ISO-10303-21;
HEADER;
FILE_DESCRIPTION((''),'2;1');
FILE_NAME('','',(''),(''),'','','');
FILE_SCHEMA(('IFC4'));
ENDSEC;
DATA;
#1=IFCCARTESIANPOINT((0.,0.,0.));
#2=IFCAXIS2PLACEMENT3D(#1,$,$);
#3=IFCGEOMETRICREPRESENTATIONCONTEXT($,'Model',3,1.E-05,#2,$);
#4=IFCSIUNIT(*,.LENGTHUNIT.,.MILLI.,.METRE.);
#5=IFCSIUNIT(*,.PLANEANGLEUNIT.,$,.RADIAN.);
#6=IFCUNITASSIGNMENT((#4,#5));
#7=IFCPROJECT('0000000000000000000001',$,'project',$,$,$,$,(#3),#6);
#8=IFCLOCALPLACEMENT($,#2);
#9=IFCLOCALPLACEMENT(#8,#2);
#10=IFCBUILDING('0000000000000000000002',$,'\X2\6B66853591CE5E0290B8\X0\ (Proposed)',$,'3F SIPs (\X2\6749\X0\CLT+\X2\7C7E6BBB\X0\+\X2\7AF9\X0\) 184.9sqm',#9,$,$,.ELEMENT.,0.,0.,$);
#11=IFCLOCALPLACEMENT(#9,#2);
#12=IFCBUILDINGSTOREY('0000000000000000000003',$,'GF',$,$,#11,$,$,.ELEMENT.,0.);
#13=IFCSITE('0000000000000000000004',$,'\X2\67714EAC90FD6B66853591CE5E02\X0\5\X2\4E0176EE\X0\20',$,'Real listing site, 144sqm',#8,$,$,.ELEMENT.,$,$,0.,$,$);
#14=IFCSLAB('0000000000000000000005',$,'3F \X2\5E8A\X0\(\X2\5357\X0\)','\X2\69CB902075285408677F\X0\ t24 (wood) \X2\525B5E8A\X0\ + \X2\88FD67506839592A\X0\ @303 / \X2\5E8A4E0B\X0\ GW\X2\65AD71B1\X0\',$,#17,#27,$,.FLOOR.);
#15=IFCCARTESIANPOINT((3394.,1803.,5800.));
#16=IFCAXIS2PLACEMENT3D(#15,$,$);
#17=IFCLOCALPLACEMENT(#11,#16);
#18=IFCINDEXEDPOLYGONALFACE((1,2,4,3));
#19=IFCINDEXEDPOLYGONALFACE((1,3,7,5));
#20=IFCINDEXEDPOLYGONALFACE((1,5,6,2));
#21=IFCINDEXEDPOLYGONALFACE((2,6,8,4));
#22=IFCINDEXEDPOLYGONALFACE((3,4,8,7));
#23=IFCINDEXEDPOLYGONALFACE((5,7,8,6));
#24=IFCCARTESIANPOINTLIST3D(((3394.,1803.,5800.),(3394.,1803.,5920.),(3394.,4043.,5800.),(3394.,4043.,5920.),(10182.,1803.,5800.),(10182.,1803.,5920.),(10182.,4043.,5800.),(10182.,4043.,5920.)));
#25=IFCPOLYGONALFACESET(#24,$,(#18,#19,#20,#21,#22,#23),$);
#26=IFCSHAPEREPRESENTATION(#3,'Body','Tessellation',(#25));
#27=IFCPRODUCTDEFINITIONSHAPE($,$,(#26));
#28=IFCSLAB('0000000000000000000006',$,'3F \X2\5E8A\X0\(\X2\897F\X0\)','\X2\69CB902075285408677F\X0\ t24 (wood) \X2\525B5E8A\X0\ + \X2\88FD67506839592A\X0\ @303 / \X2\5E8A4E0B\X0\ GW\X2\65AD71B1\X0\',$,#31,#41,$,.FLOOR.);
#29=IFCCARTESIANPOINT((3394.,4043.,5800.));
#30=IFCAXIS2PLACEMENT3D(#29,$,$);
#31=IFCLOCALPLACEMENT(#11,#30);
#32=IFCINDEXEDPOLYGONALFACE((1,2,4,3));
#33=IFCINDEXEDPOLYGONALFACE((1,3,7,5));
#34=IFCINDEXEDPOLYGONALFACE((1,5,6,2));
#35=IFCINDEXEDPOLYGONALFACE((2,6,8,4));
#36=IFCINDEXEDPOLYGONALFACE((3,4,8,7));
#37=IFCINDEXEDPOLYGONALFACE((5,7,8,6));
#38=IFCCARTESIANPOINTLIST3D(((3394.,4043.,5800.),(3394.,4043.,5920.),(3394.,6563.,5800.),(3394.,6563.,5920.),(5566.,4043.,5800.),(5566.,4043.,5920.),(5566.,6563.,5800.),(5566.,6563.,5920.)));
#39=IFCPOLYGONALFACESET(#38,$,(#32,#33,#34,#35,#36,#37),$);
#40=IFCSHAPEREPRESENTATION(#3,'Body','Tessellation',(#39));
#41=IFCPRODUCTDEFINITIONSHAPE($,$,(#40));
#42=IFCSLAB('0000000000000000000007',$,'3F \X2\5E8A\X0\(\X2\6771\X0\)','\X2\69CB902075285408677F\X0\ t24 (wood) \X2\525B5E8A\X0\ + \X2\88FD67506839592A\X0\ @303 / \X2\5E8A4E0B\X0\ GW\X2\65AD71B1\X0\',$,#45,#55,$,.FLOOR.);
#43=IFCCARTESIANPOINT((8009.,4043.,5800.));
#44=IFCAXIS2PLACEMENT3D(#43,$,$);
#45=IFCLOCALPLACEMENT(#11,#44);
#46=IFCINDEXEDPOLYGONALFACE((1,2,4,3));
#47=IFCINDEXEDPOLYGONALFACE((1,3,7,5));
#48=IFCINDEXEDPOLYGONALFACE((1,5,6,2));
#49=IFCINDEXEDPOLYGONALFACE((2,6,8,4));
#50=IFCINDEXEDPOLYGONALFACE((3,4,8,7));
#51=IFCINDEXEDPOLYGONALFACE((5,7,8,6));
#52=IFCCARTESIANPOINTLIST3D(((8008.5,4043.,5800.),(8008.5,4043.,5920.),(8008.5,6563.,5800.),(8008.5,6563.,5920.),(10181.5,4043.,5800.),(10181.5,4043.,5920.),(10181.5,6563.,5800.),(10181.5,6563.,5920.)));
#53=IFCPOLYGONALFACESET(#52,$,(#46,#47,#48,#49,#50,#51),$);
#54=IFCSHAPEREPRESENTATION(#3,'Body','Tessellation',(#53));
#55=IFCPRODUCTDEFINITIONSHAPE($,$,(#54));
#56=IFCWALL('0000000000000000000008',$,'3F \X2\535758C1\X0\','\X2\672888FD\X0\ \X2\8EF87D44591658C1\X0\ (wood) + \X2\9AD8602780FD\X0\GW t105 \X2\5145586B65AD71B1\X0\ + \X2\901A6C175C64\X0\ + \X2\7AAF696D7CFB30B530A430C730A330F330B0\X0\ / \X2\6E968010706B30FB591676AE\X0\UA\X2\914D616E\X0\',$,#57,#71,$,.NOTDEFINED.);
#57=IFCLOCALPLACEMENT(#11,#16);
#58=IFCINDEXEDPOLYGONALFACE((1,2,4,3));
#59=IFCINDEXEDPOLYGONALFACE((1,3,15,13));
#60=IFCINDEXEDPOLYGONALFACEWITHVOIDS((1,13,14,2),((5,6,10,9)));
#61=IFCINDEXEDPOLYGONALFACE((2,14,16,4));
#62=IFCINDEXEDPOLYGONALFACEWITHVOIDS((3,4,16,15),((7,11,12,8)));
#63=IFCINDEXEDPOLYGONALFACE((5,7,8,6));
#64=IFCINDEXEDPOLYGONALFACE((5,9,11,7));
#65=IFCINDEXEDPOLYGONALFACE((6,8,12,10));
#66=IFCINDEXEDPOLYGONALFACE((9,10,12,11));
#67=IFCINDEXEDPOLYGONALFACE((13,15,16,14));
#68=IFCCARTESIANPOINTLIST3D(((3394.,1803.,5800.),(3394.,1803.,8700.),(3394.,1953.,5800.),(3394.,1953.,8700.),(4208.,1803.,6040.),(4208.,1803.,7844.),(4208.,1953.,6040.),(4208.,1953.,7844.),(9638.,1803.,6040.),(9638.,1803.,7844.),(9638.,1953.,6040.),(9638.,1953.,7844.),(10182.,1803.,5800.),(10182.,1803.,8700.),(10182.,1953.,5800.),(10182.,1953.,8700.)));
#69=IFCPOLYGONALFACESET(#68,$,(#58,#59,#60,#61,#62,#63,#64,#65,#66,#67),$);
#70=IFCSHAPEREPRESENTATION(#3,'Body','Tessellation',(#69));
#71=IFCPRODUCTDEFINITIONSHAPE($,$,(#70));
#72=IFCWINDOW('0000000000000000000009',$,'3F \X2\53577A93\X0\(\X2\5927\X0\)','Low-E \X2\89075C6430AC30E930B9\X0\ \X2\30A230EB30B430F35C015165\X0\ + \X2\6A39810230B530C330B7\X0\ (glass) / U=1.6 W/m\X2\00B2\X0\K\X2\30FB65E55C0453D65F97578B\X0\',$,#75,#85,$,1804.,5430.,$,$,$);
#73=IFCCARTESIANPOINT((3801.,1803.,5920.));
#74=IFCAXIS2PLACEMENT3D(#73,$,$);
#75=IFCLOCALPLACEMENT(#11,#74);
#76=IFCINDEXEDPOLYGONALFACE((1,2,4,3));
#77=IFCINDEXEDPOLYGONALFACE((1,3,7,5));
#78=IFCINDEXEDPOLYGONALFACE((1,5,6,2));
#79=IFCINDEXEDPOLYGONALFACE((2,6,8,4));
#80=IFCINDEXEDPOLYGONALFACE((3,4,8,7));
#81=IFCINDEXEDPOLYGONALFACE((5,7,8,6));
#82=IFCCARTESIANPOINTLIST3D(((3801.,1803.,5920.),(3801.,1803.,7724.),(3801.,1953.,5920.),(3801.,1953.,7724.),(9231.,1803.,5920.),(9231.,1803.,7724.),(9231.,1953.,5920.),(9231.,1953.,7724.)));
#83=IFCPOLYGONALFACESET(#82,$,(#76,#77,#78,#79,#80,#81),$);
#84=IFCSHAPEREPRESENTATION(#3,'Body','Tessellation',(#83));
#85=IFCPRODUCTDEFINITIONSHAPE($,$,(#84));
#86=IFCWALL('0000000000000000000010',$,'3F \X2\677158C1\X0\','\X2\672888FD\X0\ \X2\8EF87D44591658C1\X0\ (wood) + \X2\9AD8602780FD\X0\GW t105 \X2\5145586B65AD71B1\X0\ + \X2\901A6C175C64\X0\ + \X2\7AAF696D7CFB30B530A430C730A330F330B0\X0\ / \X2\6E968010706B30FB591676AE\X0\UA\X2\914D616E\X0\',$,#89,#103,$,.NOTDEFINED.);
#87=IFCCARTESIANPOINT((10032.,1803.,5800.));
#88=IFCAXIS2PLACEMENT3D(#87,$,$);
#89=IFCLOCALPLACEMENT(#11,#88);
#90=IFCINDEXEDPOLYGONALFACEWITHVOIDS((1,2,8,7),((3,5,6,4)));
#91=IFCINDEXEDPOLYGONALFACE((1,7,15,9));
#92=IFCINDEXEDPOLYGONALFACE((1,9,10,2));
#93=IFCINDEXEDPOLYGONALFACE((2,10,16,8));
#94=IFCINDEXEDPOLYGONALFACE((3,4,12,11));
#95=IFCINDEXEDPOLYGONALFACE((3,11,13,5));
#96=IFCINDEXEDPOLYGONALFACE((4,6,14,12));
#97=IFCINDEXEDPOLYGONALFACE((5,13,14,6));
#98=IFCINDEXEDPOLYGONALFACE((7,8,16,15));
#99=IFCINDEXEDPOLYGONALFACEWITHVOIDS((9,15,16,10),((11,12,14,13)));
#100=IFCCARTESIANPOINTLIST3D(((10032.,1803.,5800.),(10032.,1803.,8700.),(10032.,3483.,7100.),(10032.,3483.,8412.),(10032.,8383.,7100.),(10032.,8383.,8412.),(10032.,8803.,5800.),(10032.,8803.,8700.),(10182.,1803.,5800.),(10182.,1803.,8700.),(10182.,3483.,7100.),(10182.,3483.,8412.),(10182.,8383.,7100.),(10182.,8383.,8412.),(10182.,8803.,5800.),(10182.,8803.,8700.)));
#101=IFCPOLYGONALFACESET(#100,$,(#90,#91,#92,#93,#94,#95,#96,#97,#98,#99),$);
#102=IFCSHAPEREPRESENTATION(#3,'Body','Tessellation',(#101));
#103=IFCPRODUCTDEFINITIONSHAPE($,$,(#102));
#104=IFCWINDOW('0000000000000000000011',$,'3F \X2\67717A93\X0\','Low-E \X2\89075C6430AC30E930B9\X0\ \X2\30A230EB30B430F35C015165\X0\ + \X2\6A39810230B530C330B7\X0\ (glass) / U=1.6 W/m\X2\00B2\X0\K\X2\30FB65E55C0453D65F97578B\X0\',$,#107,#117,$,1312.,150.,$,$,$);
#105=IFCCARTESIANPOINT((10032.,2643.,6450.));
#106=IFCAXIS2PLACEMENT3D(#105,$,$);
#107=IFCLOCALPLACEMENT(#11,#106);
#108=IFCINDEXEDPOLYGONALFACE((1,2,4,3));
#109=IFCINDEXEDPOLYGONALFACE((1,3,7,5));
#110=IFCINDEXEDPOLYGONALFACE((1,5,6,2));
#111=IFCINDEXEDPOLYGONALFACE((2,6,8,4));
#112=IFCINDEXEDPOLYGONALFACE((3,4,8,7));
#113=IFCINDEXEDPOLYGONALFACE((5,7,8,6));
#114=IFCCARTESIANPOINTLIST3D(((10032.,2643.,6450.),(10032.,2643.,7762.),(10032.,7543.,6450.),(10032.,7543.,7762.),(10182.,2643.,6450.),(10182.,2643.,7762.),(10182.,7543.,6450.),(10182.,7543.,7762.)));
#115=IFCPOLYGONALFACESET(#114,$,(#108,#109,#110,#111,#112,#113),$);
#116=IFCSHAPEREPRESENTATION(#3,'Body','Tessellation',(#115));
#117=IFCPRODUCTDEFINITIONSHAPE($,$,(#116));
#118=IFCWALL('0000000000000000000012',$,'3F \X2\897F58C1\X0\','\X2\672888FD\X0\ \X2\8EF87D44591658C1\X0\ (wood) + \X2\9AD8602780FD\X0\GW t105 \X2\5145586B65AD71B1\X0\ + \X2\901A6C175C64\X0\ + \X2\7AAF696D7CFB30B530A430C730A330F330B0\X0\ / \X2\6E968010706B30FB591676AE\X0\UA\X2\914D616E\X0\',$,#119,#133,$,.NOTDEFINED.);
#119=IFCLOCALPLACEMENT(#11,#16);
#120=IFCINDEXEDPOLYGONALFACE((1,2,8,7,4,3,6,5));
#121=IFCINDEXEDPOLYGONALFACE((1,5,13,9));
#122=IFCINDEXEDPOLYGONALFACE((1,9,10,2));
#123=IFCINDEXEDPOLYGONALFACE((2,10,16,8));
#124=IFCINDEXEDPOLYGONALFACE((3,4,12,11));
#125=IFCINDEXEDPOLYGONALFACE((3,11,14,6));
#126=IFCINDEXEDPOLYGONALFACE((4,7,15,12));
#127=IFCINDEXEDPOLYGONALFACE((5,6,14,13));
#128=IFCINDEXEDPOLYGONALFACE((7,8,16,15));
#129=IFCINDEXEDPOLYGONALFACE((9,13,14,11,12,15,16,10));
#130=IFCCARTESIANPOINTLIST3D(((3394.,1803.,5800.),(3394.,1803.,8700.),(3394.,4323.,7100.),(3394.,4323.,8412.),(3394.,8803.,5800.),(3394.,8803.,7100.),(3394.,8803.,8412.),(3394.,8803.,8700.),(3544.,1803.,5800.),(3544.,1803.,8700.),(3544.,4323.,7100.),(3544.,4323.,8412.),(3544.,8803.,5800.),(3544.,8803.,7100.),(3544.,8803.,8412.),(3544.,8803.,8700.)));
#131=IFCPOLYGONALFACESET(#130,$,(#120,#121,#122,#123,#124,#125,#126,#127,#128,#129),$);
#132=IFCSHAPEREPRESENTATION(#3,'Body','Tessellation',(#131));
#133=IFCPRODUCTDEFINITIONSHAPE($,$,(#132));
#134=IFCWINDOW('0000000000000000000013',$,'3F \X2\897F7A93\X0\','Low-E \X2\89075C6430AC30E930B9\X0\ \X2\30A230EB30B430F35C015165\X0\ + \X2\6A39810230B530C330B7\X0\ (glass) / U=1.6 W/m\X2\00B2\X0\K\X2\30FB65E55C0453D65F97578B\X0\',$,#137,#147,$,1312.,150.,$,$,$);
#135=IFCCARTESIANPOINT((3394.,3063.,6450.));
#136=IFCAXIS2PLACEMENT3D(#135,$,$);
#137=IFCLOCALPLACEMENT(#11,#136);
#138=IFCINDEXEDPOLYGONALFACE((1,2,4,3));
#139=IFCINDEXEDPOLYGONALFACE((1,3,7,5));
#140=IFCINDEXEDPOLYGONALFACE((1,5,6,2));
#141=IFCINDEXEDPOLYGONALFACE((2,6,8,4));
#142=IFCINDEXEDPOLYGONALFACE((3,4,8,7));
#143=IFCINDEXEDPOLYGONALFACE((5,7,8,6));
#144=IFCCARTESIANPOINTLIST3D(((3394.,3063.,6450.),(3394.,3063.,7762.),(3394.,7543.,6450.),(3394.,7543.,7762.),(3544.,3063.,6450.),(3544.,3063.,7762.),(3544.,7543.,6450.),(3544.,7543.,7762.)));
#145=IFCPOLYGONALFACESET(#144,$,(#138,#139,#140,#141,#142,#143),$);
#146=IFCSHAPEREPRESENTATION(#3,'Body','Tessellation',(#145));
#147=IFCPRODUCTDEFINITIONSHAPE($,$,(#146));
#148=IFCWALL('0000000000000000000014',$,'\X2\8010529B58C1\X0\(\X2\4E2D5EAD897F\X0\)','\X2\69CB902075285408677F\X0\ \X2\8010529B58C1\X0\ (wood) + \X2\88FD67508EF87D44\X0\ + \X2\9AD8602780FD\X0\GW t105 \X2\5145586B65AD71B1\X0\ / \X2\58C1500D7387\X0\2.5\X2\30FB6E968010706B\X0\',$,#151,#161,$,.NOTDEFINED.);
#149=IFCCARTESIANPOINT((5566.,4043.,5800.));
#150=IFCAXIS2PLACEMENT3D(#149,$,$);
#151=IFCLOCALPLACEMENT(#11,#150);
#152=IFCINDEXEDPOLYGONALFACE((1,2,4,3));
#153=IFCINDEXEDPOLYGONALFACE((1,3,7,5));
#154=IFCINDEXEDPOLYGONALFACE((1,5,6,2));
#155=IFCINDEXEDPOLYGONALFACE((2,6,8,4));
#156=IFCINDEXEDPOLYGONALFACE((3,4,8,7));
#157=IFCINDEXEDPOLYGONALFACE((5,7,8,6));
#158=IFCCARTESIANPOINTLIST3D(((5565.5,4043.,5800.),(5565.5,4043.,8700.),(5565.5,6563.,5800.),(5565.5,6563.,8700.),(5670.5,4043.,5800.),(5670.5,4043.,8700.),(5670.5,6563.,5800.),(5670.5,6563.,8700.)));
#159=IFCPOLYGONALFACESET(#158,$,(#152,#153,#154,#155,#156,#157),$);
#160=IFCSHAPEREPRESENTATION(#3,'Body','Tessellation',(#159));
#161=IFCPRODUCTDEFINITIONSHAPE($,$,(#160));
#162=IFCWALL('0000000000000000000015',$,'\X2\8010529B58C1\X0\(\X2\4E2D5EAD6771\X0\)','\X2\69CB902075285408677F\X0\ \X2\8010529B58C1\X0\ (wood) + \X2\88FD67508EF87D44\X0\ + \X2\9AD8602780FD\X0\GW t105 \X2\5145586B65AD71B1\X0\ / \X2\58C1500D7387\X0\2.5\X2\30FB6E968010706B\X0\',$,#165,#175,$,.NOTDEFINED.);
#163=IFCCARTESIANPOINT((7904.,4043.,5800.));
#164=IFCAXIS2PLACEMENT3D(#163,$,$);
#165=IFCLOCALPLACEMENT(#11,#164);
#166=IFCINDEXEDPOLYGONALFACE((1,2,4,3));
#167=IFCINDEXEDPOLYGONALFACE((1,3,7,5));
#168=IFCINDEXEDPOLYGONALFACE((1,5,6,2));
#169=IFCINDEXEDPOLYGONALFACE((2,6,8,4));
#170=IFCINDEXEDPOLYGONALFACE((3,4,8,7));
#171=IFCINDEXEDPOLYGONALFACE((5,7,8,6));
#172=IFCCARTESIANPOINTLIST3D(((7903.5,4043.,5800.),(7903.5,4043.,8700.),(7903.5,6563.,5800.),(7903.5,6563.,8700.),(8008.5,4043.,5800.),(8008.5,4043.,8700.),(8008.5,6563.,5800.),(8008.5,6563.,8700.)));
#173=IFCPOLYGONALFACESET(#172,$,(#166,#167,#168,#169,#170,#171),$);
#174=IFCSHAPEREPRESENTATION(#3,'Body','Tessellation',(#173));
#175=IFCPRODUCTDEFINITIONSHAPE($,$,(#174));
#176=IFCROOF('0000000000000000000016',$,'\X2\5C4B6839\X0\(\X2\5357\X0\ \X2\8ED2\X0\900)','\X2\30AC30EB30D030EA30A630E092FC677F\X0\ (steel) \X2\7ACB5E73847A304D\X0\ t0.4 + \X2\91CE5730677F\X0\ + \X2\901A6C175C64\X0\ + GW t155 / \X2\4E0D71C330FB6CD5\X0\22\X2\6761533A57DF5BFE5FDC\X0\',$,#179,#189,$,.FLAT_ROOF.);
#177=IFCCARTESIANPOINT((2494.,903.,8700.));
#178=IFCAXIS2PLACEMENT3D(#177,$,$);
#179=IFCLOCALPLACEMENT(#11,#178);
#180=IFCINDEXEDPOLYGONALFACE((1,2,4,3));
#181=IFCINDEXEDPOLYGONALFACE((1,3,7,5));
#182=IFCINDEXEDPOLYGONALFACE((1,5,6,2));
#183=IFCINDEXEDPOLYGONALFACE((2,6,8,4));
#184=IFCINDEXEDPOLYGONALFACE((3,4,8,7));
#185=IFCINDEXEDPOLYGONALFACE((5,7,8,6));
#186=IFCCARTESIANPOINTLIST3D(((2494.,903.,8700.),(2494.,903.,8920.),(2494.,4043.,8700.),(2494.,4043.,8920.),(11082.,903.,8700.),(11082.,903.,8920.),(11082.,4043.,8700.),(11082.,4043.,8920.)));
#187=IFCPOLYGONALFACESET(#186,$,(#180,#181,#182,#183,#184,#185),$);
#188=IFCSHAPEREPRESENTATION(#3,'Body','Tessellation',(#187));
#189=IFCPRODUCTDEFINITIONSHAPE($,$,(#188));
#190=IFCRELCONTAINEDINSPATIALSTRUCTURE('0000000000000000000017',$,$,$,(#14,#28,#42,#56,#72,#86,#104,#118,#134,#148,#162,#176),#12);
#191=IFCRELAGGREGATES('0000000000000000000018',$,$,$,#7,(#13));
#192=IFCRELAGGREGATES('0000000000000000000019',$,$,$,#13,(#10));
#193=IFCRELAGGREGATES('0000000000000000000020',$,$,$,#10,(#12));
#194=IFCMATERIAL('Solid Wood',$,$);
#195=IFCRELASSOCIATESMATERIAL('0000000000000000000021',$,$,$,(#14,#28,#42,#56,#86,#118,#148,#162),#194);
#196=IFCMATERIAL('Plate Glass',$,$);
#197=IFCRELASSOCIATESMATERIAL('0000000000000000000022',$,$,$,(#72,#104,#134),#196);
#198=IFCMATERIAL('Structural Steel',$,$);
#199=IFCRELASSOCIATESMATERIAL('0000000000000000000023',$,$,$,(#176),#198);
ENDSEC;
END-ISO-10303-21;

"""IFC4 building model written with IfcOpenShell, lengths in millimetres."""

from ifc_helpers import new_model, si_unit, frame, frame_2d, origin, place, context, project, spatial, rectangle, extrude, material, element, fill, save


model = new_model("IFC4")

# Units and contexts
model_context = context("Model", 3, precision=1e-05, world=origin())
ifc_project = project(units=[si_unit("LENGTHUNIT", "METRE", prefix="MILLI"), si_unit("PLANEANGLEUNIT", "RADIAN")], contexts=[model_context])

# Site, building, storey
site_placement = place(None, origin())
site = spatial("IfcSite", under=ifc_project, at=site_placement, Name="東京都武蔵野市5丁目20", ObjectType="Real listing site, 144sqm", CompositionType="ELEMENT", RefElevation=0.0)
building_placement = place(site_placement, origin())
building = spatial("IfcBuilding", under=site, at=building_placement, Name="武蔵野市邸 (Proposed)", ObjectType="3F SIPs (杉CLT+籾殻+竹) 184.9sqm", CompositionType="ELEMENT", ElevationOfRefHeight=0.0, ElevationOfTerrain=0.0)
storey_placement = place(building_placement, origin())
storey = spatial("IfcBuildingStorey", under=building, at=storey_placement, Name="GF", CompositionType="ELEMENT", Elevation=0.0)

# Slabs
ifc_material_1 = material(Name="Solid Wood")
slab_1_placement = place(storey_placement, frame((3394.0, 1803.0, 5800.0)))
element("IfcSlab", 1, at=slab_1_placement, inside=storey, material=ifc_material_1, Name="3F 床(南)", Description="構造用合板 t24 (wood) 剛床 + 製材根太 @303 / 床下 GW断熱", PredefinedType="FLOOR", context=model_context, shape_type="SweptSolid", body=[
    extrude(rectangle(XDim=6788.0, YDim=2240.0, at=frame_2d((3394.0, 1120.0))), frame((3394.0, 1803.0, 5800.0)), (0.0, 0.0, 1.0), 120.0),
])
slab_2_placement = place(storey_placement, frame((3394.0, 4043.0, 5800.0)))
element("IfcSlab", 2, at=slab_2_placement, inside=storey, material=ifc_material_1, Name="3F 床(西)", Description="構造用合板 t24 (wood) 剛床 + 製材根太 @303 / 床下 GW断熱", PredefinedType="FLOOR", context=model_context, shape_type="SweptSolid", body=[
    extrude(rectangle(XDim=2172.0, YDim=2520.0, at=frame_2d((1086.0, 1260.0))), frame((3394.0, 4043.0, 5800.0)), (0.0, 0.0, 1.0), 120.0),
])
slab_3_placement = place(storey_placement, frame((8009.0, 4043.0, 5800.0)))
element("IfcSlab", 3, at=slab_3_placement, inside=storey, material=ifc_material_1, Name="3F 床(東)", Description="構造用合板 t24 (wood) 剛床 + 製材根太 @303 / 床下 GW断熱", PredefinedType="FLOOR", context=model_context, shape_type="SweptSolid", body=[
    extrude(rectangle(XDim=2173.0, YDim=2520.0, at=frame_2d((1086.0, 1260.0))), frame((8009.0, 4043.0, 5800.0)), (0.0, 0.0, 1.0), 120.0),
])

# Walls, openings, windows
wall_1_placement = place(storey_placement, frame((3394.0, 1803.0, 5800.0)))
wall_1 = element("IfcWall", 4, at=wall_1_placement, inside=storey, material=ifc_material_1, Name="3F 南壁", Description="木製 軸組外壁 (wood) + 高性能GW t105 充填断熱 + 通気層 + 窯業系サイディング / 準耐火・外皮UA配慮", PredefinedType="NOTDEFINED", context=model_context, shape_type="SweptSolid", body=[
    extrude(rectangle(XDim=6788.0, YDim=150.0, at=frame_2d((3394.0, 75.0))), frame((3394.0, 1803.0, 5800.0)), (0.0, 0.0, 1.0), 2900.0),
])
opening_1_placement = place(storey_placement, frame((3801.0, 1803.0, 5920.0)))
opening_1 = element("IfcOpeningElement", 5, at=opening_1_placement, cuts=wall_1, PredefinedType="NOTDEFINED", context=model_context, shape_type="SweptSolid", body=[
    extrude(rectangle(XDim=5430.0, YDim=150.0, at=frame_2d((2715.0, 75.0))), frame((3801.0, 1803.0, 5920.0)), (0.0, 0.0, 1.0), 1804.0),
])
ifc_material_2 = material(Name="Plate Glass")
window_1_placement = place(storey_placement, frame((3801.0, 1803.0, 5920.0)))
window_1 = element("IfcWindow", 6, at=window_1_placement, inside=storey, material=ifc_material_2, Name="3F 南窓(大)", Description="Low-E 複層ガラス アルゴン封入 + 樹脂サッシ (glass) / U=1.6 W/m²K・日射取得型", OverallHeight=1804.0, OverallWidth=5430.0, context=model_context, shape_type="SweptSolid", body=[
    extrude(rectangle(XDim=5430.0, YDim=150.0, at=frame_2d((2715.0, 75.0))), frame((3801.0, 1803.0, 5920.0)), (0.0, 0.0, 1.0), 1804.0),
])
fill(opening_1, window_1)
wall_2_placement = place(storey_placement, frame((10032.0, 1803.0, 5800.0)))
wall_2 = element("IfcWall", 7, at=wall_2_placement, inside=storey, material=ifc_material_1, Name="3F 東壁", Description="木製 軸組外壁 (wood) + 高性能GW t105 充填断熱 + 通気層 + 窯業系サイディング / 準耐火・外皮UA配慮", PredefinedType="NOTDEFINED", context=model_context, shape_type="SweptSolid", body=[
    extrude(rectangle(XDim=150.0, YDim=7000.0, at=frame_2d((75.0, 3500.0))), frame((10032.0, 1803.0, 5800.0)), (0.0, 0.0, 1.0), 2900.0),
])
opening_2_placement = place(storey_placement, frame((10032.0, 2643.0, 6450.0)))
opening_2 = element("IfcOpeningElement", 8, at=opening_2_placement, cuts=wall_2, PredefinedType="NOTDEFINED", context=model_context, shape_type="SweptSolid", body=[
    extrude(rectangle(XDim=150.0, YDim=4900.0, at=frame_2d((75.0, 2450.0))), frame((10032.0, 2643.0, 6450.0)), (0.0, 0.0, 1.0), 1312.0),
])
window_2_placement = place(storey_placement, frame((10032.0, 2643.0, 6450.0)))
window_2 = element("IfcWindow", 9, at=window_2_placement, inside=storey, material=ifc_material_2, Name="3F 東窓", Description="Low-E 複層ガラス アルゴン封入 + 樹脂サッシ (glass) / U=1.6 W/m²K・日射取得型", OverallHeight=1312.0, OverallWidth=150.0, context=model_context, shape_type="SweptSolid", body=[
    extrude(rectangle(XDim=150.0, YDim=4900.0, at=frame_2d((75.0, 2450.0))), frame((10032.0, 2643.0, 6450.0)), (0.0, 0.0, 1.0), 1312.0),
])
fill(opening_2, window_2)
wall_3_placement = place(storey_placement, frame((3394.0, 1803.0, 5800.0)))
wall_3 = element("IfcWall", 10, at=wall_3_placement, inside=storey, material=ifc_material_1, Name="3F 西壁", Description="木製 軸組外壁 (wood) + 高性能GW t105 充填断熱 + 通気層 + 窯業系サイディング / 準耐火・外皮UA配慮", PredefinedType="NOTDEFINED", context=model_context, shape_type="SweptSolid", body=[
    extrude(rectangle(XDim=150.0, YDim=7000.0, at=frame_2d((75.0, 3500.0))), frame((3394.0, 1803.0, 5800.0)), (0.0, 0.0, 1.0), 2900.0),
])
opening_3_placement = place(storey_placement, frame((3394.0, 3063.0, 6450.0)))
opening_3 = element("IfcOpeningElement", 11, at=opening_3_placement, cuts=wall_3, PredefinedType="NOTDEFINED", context=model_context, shape_type="SweptSolid", body=[
    extrude(rectangle(XDim=150.0, YDim=4480.0, at=frame_2d((75.0, 2240.0))), frame((3394.0, 3063.0, 6450.0)), (0.0, 0.0, 1.0), 1312.0),
])
window_3_placement = place(storey_placement, frame((3394.0, 3063.0, 6450.0)))
window_3 = element("IfcWindow", 12, at=window_3_placement, inside=storey, material=ifc_material_2, Name="3F 西窓", Description="Low-E 複層ガラス アルゴン封入 + 樹脂サッシ (glass) / U=1.6 W/m²K・日射取得型", OverallHeight=1312.0, OverallWidth=150.0, context=model_context, shape_type="SweptSolid", body=[
    extrude(rectangle(XDim=150.0, YDim=4480.0, at=frame_2d((75.0, 2240.0))), frame((3394.0, 3063.0, 6450.0)), (0.0, 0.0, 1.0), 1312.0),
])
fill(opening_3, window_3)

# Walls
wall_4_placement = place(storey_placement, frame((5566.0, 4043.0, 5800.0)))
element("IfcWall", 13, at=wall_4_placement, inside=storey, material=ifc_material_1, Name="耐力壁(中庭西)", Description="構造用合板 耐力壁 (wood) + 製材軸組 + 高性能GW t105 充填断熱 / 壁倍率2.5・準耐火", PredefinedType="NOTDEFINED", context=model_context, shape_type="SweptSolid", body=[
    extrude(rectangle(XDim=105.0, YDim=2520.0, at=frame_2d((52.0, 1260.0))), frame((5566.0, 4043.0, 5800.0)), (0.0, 0.0, 1.0), 2900.0),
])
wall_5_placement = place(storey_placement, frame((7904.0, 4043.0, 5800.0)))
element("IfcWall", 14, at=wall_5_placement, inside=storey, material=ifc_material_1, Name="耐力壁(中庭東)", Description="構造用合板 耐力壁 (wood) + 製材軸組 + 高性能GW t105 充填断熱 / 壁倍率2.5・準耐火", PredefinedType="NOTDEFINED", context=model_context, shape_type="SweptSolid", body=[
    extrude(rectangle(XDim=105.0, YDim=2520.0, at=frame_2d((52.0, 1260.0))), frame((7904.0, 4043.0, 5800.0)), (0.0, 0.0, 1.0), 2900.0),
])

# Roof
ifc_material_3 = material(Name="Structural Steel")
roof_1_placement = place(storey_placement, frame((2494.0, 903.0, 8700.0)))
element("IfcRoof", 15, at=roof_1_placement, inside=storey, material=ifc_material_3, Name="屋根(南 軒900)", Description="ガルバリウム鋼板 (steel) 立平葺き t0.4 + 野地板 + 通気層 + GW t155 / 不燃・法22条区域対応", PredefinedType="FLAT_ROOF", context=model_context, shape_type="SweptSolid", body=[
    extrude(rectangle(XDim=8588.0, YDim=3140.0, at=frame_2d((4294.0, 1570.0))), frame((2494.0, 903.0, 8700.0)), (0.0, 0.0, 1.0), 220.0),
])

save(model, "model.ifc")
